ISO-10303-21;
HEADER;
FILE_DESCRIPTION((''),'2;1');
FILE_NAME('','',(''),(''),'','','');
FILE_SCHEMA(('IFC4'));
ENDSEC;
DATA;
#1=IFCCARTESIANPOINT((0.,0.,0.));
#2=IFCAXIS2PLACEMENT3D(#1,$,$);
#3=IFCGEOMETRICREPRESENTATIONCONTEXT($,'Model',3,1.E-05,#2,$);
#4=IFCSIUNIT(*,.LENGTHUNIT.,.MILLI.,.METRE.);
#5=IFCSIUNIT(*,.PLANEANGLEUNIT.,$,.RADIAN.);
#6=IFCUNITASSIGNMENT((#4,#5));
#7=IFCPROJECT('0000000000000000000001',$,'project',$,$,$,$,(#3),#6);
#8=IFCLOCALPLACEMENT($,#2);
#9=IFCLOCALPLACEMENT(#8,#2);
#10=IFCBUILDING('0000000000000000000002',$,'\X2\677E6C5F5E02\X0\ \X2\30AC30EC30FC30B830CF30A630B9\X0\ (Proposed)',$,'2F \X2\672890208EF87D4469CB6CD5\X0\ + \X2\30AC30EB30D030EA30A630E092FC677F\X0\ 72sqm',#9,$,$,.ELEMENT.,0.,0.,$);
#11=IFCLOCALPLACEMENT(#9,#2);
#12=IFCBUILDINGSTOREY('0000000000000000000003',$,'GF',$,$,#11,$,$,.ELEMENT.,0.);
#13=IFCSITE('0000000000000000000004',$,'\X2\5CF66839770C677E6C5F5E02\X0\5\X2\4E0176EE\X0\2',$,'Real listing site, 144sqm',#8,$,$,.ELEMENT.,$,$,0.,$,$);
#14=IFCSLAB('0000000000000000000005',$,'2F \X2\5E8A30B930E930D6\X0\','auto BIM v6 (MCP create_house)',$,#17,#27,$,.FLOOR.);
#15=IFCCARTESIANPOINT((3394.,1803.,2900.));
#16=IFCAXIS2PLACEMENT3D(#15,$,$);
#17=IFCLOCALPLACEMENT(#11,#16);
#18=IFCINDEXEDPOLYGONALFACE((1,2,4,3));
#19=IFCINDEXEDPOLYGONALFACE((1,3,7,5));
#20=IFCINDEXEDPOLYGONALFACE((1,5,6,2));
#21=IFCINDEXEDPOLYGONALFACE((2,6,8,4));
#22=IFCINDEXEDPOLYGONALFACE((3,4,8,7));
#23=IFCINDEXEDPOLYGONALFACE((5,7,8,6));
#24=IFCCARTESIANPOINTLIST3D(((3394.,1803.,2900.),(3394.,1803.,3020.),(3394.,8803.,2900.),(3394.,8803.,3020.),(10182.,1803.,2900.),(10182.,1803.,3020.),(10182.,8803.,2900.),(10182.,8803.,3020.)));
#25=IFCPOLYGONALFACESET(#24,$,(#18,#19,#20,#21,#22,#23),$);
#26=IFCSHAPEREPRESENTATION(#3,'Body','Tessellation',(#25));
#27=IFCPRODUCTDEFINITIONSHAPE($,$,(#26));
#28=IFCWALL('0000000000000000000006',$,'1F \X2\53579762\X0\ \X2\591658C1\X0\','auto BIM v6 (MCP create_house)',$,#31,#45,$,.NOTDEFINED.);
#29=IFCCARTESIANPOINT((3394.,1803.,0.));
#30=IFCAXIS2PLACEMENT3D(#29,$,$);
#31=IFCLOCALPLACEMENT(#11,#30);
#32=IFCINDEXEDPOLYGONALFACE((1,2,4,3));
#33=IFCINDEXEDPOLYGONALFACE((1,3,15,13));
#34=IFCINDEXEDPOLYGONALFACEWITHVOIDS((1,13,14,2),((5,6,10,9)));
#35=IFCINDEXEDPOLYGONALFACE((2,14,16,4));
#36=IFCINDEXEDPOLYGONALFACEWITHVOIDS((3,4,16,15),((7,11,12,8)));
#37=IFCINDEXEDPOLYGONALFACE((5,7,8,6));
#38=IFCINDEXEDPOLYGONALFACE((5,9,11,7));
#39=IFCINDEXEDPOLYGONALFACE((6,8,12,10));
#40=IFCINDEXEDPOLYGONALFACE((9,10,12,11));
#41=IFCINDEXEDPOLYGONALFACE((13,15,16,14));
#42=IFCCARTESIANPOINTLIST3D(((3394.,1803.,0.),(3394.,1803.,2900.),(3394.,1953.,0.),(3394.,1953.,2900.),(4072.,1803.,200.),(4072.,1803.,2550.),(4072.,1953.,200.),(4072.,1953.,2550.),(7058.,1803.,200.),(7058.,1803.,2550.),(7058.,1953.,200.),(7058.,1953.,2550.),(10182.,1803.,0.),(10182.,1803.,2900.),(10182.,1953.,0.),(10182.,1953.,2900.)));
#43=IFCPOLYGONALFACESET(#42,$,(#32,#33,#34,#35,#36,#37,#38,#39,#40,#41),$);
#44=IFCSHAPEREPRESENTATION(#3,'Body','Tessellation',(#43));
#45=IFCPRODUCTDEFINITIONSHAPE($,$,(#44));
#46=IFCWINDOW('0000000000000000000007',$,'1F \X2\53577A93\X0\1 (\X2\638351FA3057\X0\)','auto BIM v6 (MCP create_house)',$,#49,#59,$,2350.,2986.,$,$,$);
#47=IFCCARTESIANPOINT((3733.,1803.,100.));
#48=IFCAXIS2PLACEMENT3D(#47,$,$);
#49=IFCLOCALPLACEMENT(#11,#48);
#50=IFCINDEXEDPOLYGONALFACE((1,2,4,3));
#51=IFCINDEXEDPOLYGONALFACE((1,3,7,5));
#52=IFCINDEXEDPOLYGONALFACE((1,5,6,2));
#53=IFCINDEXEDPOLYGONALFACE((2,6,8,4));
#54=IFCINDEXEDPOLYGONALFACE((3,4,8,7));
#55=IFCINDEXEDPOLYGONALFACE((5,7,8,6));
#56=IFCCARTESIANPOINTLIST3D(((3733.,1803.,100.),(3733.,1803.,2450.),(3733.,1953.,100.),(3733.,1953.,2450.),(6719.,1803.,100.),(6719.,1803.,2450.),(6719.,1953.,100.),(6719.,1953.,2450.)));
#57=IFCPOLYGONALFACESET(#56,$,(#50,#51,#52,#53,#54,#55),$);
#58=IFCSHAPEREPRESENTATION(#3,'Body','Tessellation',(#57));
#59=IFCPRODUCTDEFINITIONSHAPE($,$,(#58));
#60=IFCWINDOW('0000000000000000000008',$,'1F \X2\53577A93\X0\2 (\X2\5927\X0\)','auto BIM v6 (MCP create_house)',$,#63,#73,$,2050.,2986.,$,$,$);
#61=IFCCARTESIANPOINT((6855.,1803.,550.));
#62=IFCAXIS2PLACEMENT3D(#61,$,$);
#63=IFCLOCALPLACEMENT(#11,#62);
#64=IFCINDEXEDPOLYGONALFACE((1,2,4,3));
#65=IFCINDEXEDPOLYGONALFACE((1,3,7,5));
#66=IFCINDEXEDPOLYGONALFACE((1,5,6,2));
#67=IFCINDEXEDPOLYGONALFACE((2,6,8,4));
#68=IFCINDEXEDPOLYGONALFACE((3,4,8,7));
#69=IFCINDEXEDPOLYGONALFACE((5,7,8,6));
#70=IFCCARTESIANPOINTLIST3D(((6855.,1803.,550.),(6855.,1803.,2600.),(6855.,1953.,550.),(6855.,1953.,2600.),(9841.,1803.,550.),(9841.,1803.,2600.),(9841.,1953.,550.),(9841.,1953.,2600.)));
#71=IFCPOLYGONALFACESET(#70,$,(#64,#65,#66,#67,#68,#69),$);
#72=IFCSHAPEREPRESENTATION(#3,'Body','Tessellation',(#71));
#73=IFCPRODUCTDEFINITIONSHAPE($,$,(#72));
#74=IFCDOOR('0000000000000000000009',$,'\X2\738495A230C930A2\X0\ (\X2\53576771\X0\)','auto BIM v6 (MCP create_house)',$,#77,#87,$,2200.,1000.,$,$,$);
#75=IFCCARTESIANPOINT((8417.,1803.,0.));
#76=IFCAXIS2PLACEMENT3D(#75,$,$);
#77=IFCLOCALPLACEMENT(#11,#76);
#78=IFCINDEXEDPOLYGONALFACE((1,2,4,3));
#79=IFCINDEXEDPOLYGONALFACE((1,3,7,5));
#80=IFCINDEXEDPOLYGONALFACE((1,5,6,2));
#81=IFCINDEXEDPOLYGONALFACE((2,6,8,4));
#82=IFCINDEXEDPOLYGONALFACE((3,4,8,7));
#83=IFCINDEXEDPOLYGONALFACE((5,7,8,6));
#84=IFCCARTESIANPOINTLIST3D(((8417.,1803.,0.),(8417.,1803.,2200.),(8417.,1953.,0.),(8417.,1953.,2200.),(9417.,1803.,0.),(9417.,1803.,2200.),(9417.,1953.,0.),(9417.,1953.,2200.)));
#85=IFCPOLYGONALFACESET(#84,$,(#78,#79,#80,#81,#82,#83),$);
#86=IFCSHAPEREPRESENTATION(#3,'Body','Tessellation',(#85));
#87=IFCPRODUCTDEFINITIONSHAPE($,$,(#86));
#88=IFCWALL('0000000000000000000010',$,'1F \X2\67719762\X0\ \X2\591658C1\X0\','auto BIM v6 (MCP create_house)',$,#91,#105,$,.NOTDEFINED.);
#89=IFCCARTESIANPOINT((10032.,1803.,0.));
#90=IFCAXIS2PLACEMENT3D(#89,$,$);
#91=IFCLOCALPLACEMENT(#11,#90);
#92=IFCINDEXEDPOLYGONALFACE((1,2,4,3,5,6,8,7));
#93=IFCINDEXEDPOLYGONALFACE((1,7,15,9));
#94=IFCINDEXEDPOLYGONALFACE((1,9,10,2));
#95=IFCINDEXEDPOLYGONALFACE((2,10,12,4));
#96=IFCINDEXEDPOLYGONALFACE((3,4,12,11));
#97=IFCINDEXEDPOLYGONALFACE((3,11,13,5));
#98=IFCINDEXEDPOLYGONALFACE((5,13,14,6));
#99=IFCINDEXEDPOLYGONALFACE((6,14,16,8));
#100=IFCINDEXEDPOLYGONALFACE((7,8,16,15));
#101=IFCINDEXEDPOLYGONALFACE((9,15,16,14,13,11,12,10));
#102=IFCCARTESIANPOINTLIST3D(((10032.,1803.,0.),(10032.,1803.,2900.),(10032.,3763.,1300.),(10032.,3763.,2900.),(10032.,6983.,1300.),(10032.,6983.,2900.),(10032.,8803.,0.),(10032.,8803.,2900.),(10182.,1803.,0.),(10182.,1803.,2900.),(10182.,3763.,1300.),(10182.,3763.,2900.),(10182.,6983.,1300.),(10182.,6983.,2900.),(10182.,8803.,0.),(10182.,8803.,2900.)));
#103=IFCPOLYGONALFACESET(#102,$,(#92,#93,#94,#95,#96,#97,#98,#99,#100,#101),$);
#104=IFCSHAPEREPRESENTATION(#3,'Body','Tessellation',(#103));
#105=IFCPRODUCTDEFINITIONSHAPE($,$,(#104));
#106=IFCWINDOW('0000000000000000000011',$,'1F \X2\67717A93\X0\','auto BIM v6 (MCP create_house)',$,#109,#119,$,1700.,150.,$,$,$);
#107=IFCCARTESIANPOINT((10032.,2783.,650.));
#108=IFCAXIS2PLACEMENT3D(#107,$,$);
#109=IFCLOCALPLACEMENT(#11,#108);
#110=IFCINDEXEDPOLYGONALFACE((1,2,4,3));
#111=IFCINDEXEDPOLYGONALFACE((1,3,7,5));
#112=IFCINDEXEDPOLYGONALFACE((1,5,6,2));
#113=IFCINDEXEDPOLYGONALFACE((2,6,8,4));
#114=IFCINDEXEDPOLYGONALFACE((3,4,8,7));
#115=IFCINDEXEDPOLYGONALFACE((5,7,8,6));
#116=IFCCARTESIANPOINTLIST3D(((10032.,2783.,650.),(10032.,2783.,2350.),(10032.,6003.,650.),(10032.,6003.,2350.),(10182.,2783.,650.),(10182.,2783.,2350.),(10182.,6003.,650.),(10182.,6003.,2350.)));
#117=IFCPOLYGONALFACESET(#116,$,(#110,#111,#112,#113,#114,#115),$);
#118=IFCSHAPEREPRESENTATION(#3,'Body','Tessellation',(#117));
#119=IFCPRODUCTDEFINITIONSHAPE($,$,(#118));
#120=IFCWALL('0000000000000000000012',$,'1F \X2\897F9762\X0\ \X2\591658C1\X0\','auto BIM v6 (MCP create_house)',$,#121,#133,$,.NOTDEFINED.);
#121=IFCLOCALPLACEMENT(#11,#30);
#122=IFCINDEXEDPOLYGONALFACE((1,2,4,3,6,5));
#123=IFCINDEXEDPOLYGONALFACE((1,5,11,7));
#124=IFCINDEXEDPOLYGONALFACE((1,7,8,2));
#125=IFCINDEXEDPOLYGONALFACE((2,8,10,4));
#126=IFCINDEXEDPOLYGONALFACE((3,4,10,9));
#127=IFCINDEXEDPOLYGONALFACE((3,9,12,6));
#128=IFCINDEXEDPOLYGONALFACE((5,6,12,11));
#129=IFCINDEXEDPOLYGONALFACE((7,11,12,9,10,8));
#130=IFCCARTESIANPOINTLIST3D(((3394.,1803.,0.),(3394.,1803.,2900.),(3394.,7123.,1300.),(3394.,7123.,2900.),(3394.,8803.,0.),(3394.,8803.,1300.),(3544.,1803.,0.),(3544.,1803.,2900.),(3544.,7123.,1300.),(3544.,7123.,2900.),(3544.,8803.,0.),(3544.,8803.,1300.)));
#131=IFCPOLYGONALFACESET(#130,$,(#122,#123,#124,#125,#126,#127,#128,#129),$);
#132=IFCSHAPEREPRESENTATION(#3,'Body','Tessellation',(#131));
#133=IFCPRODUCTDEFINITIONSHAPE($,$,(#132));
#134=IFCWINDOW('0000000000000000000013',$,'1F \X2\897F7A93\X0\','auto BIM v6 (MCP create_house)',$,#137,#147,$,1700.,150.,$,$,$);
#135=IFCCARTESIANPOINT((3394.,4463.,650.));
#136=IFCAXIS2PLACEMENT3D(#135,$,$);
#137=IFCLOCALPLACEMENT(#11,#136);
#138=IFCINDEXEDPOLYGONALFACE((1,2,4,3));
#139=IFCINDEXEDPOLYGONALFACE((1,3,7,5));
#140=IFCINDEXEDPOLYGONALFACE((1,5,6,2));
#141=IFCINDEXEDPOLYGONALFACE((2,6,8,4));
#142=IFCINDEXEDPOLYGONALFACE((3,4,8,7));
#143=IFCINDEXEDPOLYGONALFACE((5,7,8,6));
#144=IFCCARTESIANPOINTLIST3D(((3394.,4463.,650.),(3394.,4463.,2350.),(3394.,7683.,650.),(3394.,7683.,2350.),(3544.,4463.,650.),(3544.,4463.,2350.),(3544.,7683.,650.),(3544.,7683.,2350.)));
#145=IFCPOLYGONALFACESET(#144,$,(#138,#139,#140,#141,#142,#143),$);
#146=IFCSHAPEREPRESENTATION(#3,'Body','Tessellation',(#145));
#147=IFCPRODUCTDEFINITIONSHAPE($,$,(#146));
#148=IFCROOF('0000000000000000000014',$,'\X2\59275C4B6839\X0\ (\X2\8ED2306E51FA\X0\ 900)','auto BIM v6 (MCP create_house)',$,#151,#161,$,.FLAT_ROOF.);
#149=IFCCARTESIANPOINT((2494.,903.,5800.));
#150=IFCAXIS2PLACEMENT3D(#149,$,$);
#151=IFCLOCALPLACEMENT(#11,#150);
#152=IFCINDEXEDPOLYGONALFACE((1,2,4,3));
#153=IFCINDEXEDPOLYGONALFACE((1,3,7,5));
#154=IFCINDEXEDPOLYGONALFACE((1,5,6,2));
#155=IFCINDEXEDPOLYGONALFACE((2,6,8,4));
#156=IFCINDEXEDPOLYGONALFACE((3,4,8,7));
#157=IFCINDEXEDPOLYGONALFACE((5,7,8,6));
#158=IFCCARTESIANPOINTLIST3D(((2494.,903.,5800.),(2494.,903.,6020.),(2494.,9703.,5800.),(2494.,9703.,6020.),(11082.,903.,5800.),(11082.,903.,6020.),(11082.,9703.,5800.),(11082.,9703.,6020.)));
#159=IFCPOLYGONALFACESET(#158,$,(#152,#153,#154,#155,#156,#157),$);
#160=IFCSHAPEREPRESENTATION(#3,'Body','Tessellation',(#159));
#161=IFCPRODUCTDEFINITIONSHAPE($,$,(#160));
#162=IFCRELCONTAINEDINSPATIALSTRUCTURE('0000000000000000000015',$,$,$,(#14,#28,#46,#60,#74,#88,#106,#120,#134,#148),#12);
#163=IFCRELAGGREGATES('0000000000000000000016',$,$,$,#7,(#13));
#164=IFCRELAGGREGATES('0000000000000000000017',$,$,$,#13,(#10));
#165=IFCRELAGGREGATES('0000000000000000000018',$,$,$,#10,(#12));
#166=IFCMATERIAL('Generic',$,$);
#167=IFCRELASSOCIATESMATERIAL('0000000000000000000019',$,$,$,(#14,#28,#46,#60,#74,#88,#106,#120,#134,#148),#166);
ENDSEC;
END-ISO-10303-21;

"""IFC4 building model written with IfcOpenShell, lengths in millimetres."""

from ifc_helpers import new_model, si_unit, frame, frame_2d, origin, place, context, project, spatial, rectangle, extrude, material, element, fill, save


model = new_model("IFC4")

# Units and contexts
model_context = context("Model", 3, precision=1e-05, world=origin())
ifc_project = project(units=[si_unit("LENGTHUNIT", "METRE", prefix="MILLI"), si_unit("PLANEANGLEUNIT", "RADIAN")], contexts=[model_context])

# Site, building, storey
site_placement = place(None, origin())
site = spatial("IfcSite", under=ifc_project, at=site_placement, Name="島根県松江市5丁目2", ObjectType="Real listing site, 144sqm", CompositionType="ELEMENT", RefElevation=0.0)
building_placement = place(site_placement, origin())
building = spatial("IfcBuilding", under=site, at=building_placement, Name="松江市 ガレージハウス (Proposed)", ObjectType="2F 木造軸組構法 + ガルバリウム鋼板 72sqm", CompositionType="ELEMENT", ElevationOfRefHeight=0.0, ElevationOfTerrain=0.0)
storey_placement = place(building_placement, origin())
storey = spatial("IfcBuildingStorey", under=building, at=storey_placement, Name="GF", CompositionType="ELEMENT", Elevation=0.0)

# Slab
ifc_material = material(Name="Generic")
slab_1_placement = place(storey_placement, frame((3394.0, 1803.0, 2900.0)))
element("IfcSlab", 1, at=slab_1_placement, inside=storey, material=ifc_material, Name="2F 床スラブ", Description="auto BIM v6 (MCP create_house)", PredefinedType="FLOOR", context=model_context, shape_type="SweptSolid", body=[
    extrude(rectangle(XDim=6788.0, YDim=7000.0, at=frame_2d((3394.0, 3500.0))), frame((3394.0, 1803.0, 2900.0)), (0.0, 0.0, 1.0), 120.0),
])

# Wall, openings, windows, door
wall_1_placement = place(storey_placement, frame((3394.0, 1803.0, 0.0)))
wall_1 = element("IfcWall", 2, at=wall_1_placement, inside=storey, material=ifc_material, Name="1F 南面 外壁", Description="auto BIM v6 (MCP create_house)", PredefinedType="NOTDEFINED", context=model_context, shape_type="SweptSolid", body=[
    extrude(rectangle(XDim=6788.0, YDim=150.0, at=frame_2d((3394.0, 75.0))), frame((3394.0, 1803.0, 0.0)), (0.0, 0.0, 1.0), 2900.0),
])
opening_1_placement = place(storey_placement, frame((3733.0, 1803.0, 100.0)))
opening_1 = element("IfcOpeningElement", 3, at=opening_1_placement, cuts=wall_1, PredefinedType="NOTDEFINED", context=model_context, shape_type="SweptSolid", body=[
    extrude(rectangle(XDim=2986.0, YDim=150.0, at=frame_2d((1493.0, 75.0))), frame((3733.0, 1803.0, 100.0)), (0.0, 0.0, 1.0), 2350.0),
])
opening_2_placement = place(storey_placement, frame((6855.0, 1803.0, 550.0)))
opening_2 = element("IfcOpeningElement", 4, at=opening_2_placement, cuts=wall_1, PredefinedType="NOTDEFINED", context=model_context, shape_type="SweptSolid", body=[
    extrude(rectangle(XDim=2986.0, YDim=150.0, at=frame_2d((1493.0, 75.0))), frame((6855.0, 1803.0, 550.0)), (0.0, 0.0, 1.0), 2050.0),
])
opening_3_placement = place(storey_placement, frame((8417.0, 1803.0, 0.0)))
opening_3 = element("IfcOpeningElement", 5, at=opening_3_placement, cuts=wall_1, PredefinedType="NOTDEFINED", context=model_context, shape_type="SweptSolid", body=[
    extrude(rectangle(XDim=1000.0, YDim=150.0, at=frame_2d((500.0, 75.0))), frame((8417.0, 1803.0, 0.0)), (0.0, 0.0, 1.0), 2200.0),
])
window_1_placement = place(storey_placement, frame((3733.0, 1803.0, 100.0)))
window_1 = element("IfcWindow", 6, at=window_1_placement, inside=storey, material=ifc_material, Name="1F 南窓1 (掃出し)", Description="auto BIM v6 (MCP create_house)", OverallHeight=2350.0, OverallWidth=2986.0, context=model_context, shape_type="SweptSolid", body=[
    extrude(rectangle(XDim=2986.0, YDim=150.0, at=frame_2d((1493.0, 75.0))), frame((3733.0, 1803.0, 100.0)), (0.0, 0.0, 1.0), 2350.0),
])
fill(opening_1, window_1)
window_2_placement = place(storey_placement, frame((6855.0, 1803.0, 550.0)))
window_2 = element("IfcWindow", 7, at=window_2_placement, inside=storey, material=ifc_material, Name="1F 南窓2 (大)", Description="auto BIM v6 (MCP create_house)", OverallHeight=2050.0, OverallWidth=2986.0, context=model_context, shape_type="SweptSolid", body=[
    extrude(rectangle(XDim=2986.0, YDim=150.0, at=frame_2d((1493.0, 75.0))), frame((6855.0, 1803.0, 550.0)), (0.0, 0.0, 1.0), 2050.0),
])
fill(opening_2, window_2)
door_placement = place(storey_placement, frame((8417.0, 1803.0, 0.0)))
door = element("IfcDoor", 8, at=door_placement, inside=storey, material=ifc_material, Name="玄関ドア (南東)", Description="auto BIM v6 (MCP create_house)", OverallHeight=2200.0, OverallWidth=1000.0, context=model_context, shape_type="SweptSolid", body=[
    extrude(rectangle(XDim=1000.0, YDim=150.0, at=frame_2d((500.0, 75.0))), frame((8417.0, 1803.0, 0.0)), (0.0, 0.0, 1.0), 2200.0),
])
fill(opening_3, door)

# Walls, openings, windows
wall_2_placement = place(storey_placement, frame((10032.0, 1803.0, 0.0)))
wall_2 = element("IfcWall", 9, at=wall_2_placement, inside=storey, material=ifc_material, Name="1F 東面 外壁", Description="auto BIM v6 (MCP create_house)", PredefinedType="NOTDEFINED", context=model_context, shape_type="SweptSolid", body=[
    extrude(rectangle(XDim=150.0, YDim=7000.0, at=frame_2d((75.0, 3500.0))), frame((10032.0, 1803.0, 0.0)), (0.0, 0.0, 1.0), 2900.0),
])
opening_4_placement = place(storey_placement, frame((10032.0, 2783.0, 650.0)))
opening_4 = element("IfcOpeningElement", 10, at=opening_4_placement, cuts=wall_2, PredefinedType="NOTDEFINED", context=model_context, shape_type="SweptSolid", body=[
    extrude(rectangle(XDim=150.0, YDim=3220.0, at=frame_2d((75.0, 1610.0))), frame((10032.0, 2783.0, 650.0)), (0.0, 0.0, 1.0), 1700.0),
])
window_3_placement = place(storey_placement, frame((10032.0, 2783.0, 650.0)))
window_3 = element("IfcWindow", 11, at=window_3_placement, inside=storey, material=ifc_material, Name="1F 東窓", Description="auto BIM v6 (MCP create_house)", OverallHeight=1700.0, OverallWidth=150.0, context=model_context, shape_type="SweptSolid", body=[
    extrude(rectangle(XDim=150.0, YDim=3220.0, at=frame_2d((75.0, 1610.0))), frame((10032.0, 2783.0, 650.0)), (0.0, 0.0, 1.0), 1700.0),
])
fill(opening_4, window_3)
wall_3_placement = place(storey_placement, frame((3394.0, 1803.0, 0.0)))
wall_3 = element("IfcWall", 12, at=wall_3_placement, inside=storey, material=ifc_material, Name="1F 西面 外壁", Description="auto BIM v6 (MCP create_house)", PredefinedType="NOTDEFINED", context=model_context, shape_type="SweptSolid", body=[
    extrude(rectangle(XDim=150.0, YDim=7000.0, at=frame_2d((75.0, 3500.0))), frame((3394.0, 1803.0, 0.0)), (0.0, 0.0, 1.0), 2900.0),
])
opening_5_placement = place(storey_placement, frame((3394.0, 4463.0, 650.0)))
opening_5 = element("IfcOpeningElement", 13, at=opening_5_placement, cuts=wall_3, PredefinedType="NOTDEFINED", context=model_context, shape_type="SweptSolid", body=[
    extrude(rectangle(XDim=150.0, YDim=3220.0, at=frame_2d((75.0, 1610.0))), frame((3394.0, 4463.0, 650.0)), (0.0, 0.0, 1.0), 1700.0),
])
window_4_placement = place(storey_placement, frame((3394.0, 4463.0, 650.0)))
window_4 = element("IfcWindow", 14, at=window_4_placement, inside=storey, material=ifc_material, Name="1F 西窓", Description="auto BIM v6 (MCP create_house)", OverallHeight=1700.0, OverallWidth=150.0, context=model_context, shape_type="SweptSolid", body=[
    extrude(rectangle(XDim=150.0, YDim=3220.0, at=frame_2d((75.0, 1610.0))), frame((3394.0, 4463.0, 650.0)), (0.0, 0.0, 1.0), 1700.0),
])
fill(opening_5, window_4)

# Roof
roof_placement = place(storey_placement, frame((2494.0, 903.0, 5800.0)))
element("IfcRoof", 15, at=roof_placement, inside=storey, material=ifc_material, Name="大屋根 (軒の出 900)", Description="auto BIM v6 (MCP create_house)", PredefinedType="FLAT_ROOF", context=model_context, shape_type="SweptSolid", body=[
    extrude(rectangle(XDim=8588.0, YDim=8800.0, at=frame_2d((4294.0, 4400.0))), frame((2494.0, 903.0, 5800.0)), (0.0, 0.0, 1.0), 220.0),
])

save(model, "model.ifc")
